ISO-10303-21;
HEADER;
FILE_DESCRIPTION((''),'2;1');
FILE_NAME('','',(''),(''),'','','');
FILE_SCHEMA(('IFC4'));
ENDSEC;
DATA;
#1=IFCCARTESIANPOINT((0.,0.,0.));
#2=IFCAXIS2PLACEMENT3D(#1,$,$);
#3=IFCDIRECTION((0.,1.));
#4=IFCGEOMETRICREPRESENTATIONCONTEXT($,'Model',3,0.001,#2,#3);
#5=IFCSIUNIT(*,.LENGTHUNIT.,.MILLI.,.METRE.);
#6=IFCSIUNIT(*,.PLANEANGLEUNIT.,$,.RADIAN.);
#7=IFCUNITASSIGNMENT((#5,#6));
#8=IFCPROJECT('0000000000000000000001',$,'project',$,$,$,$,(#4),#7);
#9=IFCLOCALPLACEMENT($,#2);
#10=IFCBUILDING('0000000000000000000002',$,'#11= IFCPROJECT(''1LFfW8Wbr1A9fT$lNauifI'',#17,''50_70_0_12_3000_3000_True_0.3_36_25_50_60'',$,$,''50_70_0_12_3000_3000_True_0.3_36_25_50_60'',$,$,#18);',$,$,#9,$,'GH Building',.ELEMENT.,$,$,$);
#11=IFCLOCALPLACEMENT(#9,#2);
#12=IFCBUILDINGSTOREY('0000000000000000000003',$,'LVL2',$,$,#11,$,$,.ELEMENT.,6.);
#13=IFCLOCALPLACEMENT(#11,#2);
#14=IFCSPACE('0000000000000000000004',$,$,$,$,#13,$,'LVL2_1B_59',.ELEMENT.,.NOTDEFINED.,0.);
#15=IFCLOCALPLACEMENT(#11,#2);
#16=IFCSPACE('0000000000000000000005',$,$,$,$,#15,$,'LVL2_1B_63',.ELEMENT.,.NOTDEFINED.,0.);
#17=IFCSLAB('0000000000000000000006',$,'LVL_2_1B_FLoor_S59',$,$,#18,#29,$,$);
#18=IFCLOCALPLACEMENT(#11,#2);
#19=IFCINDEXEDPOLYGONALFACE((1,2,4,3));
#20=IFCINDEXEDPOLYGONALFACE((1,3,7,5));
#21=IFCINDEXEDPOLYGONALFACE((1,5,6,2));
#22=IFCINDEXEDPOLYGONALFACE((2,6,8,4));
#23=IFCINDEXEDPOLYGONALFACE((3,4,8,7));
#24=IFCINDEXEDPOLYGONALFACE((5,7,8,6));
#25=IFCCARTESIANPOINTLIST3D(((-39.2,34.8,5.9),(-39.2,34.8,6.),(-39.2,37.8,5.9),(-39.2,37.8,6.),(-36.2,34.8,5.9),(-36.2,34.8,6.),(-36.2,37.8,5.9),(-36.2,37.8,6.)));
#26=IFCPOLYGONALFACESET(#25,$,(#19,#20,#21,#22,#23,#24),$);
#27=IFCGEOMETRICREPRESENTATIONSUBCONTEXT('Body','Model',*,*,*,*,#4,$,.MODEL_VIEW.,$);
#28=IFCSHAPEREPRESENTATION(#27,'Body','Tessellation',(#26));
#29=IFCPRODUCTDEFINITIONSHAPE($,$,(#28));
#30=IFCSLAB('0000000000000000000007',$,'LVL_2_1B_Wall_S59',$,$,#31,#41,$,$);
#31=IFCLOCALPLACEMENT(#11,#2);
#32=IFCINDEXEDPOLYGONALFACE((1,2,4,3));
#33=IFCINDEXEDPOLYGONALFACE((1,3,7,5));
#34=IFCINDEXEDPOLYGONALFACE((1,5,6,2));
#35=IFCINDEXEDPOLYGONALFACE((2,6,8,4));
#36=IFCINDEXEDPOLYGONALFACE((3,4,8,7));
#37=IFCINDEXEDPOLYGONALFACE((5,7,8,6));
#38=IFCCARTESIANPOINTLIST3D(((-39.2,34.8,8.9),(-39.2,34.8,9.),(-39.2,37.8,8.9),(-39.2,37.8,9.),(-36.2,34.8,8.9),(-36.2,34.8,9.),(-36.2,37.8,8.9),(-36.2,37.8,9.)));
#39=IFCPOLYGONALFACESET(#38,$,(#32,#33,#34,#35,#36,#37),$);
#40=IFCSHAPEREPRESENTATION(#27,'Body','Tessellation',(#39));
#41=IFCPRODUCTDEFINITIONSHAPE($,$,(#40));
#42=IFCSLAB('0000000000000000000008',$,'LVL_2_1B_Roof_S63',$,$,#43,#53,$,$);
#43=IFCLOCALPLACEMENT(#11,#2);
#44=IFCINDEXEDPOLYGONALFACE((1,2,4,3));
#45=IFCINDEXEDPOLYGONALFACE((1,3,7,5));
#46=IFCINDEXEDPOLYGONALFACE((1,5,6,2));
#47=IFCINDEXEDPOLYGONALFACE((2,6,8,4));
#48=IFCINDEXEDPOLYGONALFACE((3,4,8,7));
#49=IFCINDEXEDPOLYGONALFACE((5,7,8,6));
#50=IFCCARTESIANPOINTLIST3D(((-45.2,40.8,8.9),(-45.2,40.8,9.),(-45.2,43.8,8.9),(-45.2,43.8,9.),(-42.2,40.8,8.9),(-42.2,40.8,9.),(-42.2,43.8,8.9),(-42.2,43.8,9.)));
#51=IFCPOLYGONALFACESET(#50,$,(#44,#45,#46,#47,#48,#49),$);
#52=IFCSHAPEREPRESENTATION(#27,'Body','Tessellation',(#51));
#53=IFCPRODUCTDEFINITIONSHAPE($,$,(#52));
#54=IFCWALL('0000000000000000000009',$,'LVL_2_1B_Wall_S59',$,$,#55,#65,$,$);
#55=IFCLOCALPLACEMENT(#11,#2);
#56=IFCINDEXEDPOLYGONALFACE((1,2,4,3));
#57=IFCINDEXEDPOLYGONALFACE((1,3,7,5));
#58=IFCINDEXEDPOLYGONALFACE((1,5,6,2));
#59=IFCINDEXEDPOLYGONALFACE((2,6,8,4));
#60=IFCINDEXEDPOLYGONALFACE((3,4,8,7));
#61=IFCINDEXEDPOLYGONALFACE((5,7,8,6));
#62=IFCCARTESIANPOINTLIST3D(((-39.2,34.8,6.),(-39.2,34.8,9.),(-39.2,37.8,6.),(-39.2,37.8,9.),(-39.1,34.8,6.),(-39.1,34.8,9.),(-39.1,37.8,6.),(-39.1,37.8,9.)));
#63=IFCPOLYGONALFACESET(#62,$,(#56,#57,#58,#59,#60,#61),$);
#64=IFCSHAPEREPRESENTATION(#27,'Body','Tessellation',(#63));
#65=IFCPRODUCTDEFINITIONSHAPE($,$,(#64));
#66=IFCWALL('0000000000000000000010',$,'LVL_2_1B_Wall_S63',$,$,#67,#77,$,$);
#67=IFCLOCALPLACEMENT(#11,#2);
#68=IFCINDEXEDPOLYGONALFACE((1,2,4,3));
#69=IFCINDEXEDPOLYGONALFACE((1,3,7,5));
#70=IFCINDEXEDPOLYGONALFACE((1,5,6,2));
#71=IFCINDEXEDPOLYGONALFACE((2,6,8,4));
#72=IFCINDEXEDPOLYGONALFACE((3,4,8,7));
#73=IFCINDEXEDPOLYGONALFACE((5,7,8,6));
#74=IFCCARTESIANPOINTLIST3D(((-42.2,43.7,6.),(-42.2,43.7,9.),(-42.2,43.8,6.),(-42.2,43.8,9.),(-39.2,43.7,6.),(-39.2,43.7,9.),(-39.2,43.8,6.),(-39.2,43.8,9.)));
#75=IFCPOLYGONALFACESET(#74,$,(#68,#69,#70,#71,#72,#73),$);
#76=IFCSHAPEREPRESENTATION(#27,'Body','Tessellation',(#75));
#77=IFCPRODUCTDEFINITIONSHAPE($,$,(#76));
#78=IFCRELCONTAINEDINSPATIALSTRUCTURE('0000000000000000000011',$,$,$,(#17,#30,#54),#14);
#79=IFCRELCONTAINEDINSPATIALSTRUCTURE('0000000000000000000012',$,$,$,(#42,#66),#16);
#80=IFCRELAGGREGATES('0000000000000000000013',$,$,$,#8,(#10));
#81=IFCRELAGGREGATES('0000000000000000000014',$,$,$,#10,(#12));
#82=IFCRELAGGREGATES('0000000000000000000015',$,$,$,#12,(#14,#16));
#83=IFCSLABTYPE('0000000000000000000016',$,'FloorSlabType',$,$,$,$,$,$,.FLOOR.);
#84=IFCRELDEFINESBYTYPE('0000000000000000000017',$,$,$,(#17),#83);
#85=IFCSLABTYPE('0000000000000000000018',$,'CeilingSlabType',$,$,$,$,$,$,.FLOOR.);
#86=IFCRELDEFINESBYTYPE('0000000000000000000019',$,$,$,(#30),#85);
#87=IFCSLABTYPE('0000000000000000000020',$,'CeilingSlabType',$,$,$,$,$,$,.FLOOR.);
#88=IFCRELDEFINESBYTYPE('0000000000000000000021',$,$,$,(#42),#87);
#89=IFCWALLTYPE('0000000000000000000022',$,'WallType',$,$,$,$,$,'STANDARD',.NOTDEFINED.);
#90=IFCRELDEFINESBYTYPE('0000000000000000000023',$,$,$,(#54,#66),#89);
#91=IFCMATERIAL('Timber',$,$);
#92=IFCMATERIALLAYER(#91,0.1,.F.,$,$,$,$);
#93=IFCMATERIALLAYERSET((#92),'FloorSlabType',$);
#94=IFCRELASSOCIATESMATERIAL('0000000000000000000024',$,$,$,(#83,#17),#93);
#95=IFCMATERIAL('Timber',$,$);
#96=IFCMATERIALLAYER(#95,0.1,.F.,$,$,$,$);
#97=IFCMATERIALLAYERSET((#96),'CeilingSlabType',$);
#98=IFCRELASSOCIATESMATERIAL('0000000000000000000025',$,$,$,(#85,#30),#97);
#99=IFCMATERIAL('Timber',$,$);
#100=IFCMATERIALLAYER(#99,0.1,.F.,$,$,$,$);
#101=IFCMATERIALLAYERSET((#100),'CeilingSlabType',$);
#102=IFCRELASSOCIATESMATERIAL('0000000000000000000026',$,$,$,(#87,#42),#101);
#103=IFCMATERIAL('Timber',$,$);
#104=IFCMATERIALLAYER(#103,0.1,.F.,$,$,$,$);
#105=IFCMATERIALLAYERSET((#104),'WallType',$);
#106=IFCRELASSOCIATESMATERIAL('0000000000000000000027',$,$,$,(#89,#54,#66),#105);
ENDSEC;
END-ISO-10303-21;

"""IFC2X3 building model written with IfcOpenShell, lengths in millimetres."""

from ifc_helpers import new_model, si_unit, direction, frame, frame_2d, origin, place, context, subcontext, project, spatial, rectangle, extrude, material, layer, layer_set, layer_usage, type_object, element, save


model = new_model("IFC2X3")

# Units and contexts
model_context = context("Model", 3, precision=0.001, world=origin(), true_north=direction((0.0, 1.0)))
body_context = subcontext(model_context, "Body", "Model", "MODEL_VIEW")
ifc_project = project(units=[si_unit("LENGTHUNIT", "METRE", prefix="MILLI"), si_unit("PLANEANGLEUNIT", "RADIAN")], contexts=[model_context])

# Building, storey
building_placement = place(None, origin())
building = spatial("IfcBuilding", under=ifc_project, at=building_placement, Name="#11= IFCPROJECT('1LFfW8Wbr1A9fT$lNauifI',#17,'50_70_0_12_3000_3000_True_0.3_36_25_50_60',$,$,'50_70_0_12_3000_3000_True_0.3_36_25_50_60',$,$,#18);", LongName="GH Building", CompositionType="ELEMENT")
storey_placement = place(building_placement, origin())
storey = spatial("IfcBuildingStorey", under=building, at=storey_placement, Name="LVL2", CompositionType="ELEMENT", Elevation=6.0)

# Shared definitions
space_1_placement = place(storey_placement, origin())
space_1 = spatial("IfcSpace", under=storey, at=space_1_placement, LongName="LVL2_1B_59", CompositionType="ELEMENT", InteriorOrExteriorSpace="NOTDEFINED", ElevationWithFlooring=0.0)

# Slabs
ifc_material_1 = material(Name="Timber")
ifc_layer_1 = layer(ifc_material_1, 0.1, ventilated=False)
ifc_layer_set_1 = layer_set([ifc_layer_1], Name="FloorSlabType")
ifc_layer_usage_1 = layer_usage(ifc_layer_set_1, "AXIS3", "NEGATIVE", -0.1)
slab_type_1 = type_object("IfcSlabType", Name="FloorSlabType", PredefinedType="FLOOR", material=ifc_layer_set_1)
slab_1_placement = place(space_1_placement, frame((-39.2, 37.8, 5.9), z_axis=(0.0, 0.0, 1.0), x_axis=(0.0, -1.0, 0.0)))
element("IfcSlab", 1, at=slab_1_placement, inside=space_1, type_object=slab_type_1, material=ifc_layer_usage_1, Name="LVL_2_1B_FLoor_S59", context=body_context, shape_type="SweptSolid", body=[
    extrude(rectangle(XDim=3.0, YDim=3.0, at=frame_2d((1.5, 1.5))), origin(), (0.0, 0.0, 1.0), 0.1),
])
ifc_material_2 = material(Name="Timber")
ifc_layer_2 = layer(ifc_material_2, 0.1, ventilated=False)
ifc_layer_set_2 = layer_set([ifc_layer_2], Name="CeilingSlabType")
ifc_layer_usage_2 = layer_usage(ifc_layer_set_2, "AXIS3", "NEGATIVE", -0.1)
slab_type_2 = type_object("IfcSlabType", Name="CeilingSlabType", PredefinedType="FLOOR", material=ifc_layer_set_2)
slab_2_placement = place(space_1_placement, frame((-39.2, 37.8, 8.9), z_axis=(0.0, 0.0, 1.0), x_axis=(0.0, -1.0, 0.0)))
element("IfcSlab", 2, at=slab_2_placement, inside=space_1, type_object=slab_type_2, material=ifc_layer_usage_2, Name="LVL_2_1B_Wall_S59", context=body_context, shape_type="SweptSolid", body=[
    extrude(rectangle(XDim=3.0, YDim=3.0, at=frame_2d((1.5, 1.5))), origin(), (0.0, 0.0, 1.0), 0.1),
])

# Shared definitions
space_2_placement = place(storey_placement, origin())
space_2 = spatial("IfcSpace", under=storey, at=space_2_placement, LongName="LVL2_1B_63", CompositionType="ELEMENT", InteriorOrExteriorSpace="NOTDEFINED", ElevationWithFlooring=0.0)

# Slab
ifc_material_3 = material(Name="Timber")
ifc_layer_3 = layer(ifc_material_3, 0.1, ventilated=False)
ifc_layer_set_3 = layer_set([ifc_layer_3], Name="CeilingSlabType")
ifc_layer_usage_3 = layer_usage(ifc_layer_set_3, "AXIS3", "NEGATIVE", -0.1)
slab_type_3 = type_object("IfcSlabType", Name="CeilingSlabType", PredefinedType="FLOOR", material=ifc_layer_set_3)
slab_3_placement = place(space_2_placement, frame((-42.2, 43.8, 8.9), z_axis=(0.0, 0.0, 1.0), x_axis=(-1.0, 0.0, 0.0)))
element("IfcSlab", 3, at=slab_3_placement, inside=space_2, type_object=slab_type_3, material=ifc_layer_usage_3, Name="LVL_2_1B_Roof_S63", context=body_context, shape_type="SweptSolid", body=[
    extrude(rectangle(XDim=3.0, YDim=3.0, at=frame_2d((1.5, 1.5))), origin(), (0.0, 0.0, 1.0), 0.1),
])

# Walls
ifc_material_4 = material(Name="Timber")
ifc_layer_4 = layer(ifc_material_4, 0.1, ventilated=False)
ifc_layer_set_4 = layer_set([ifc_layer_4], Name="WallType")
ifc_layer_usage_4 = layer_usage(ifc_layer_set_4, "AXIS2", "NEGATIVE", 0.0)
wall_type_1 = type_object("IfcWallType", Name="WallType", ElementType="STANDARD", PredefinedType="NOTDEFINED", material=ifc_layer_set_4)
wall_1_placement = place(space_1_placement, frame((-39.2, 34.8, 6.0), z_axis=(0.0, 0.0, 1.0), x_axis=(0.0, 1.0, 0.0)))
element("IfcWall", 4, at=wall_1_placement, inside=space_1, type_object=wall_type_1, material=ifc_layer_usage_4, Name="LVL_2_1B_Wall_S59", context=body_context, shape_type="SweptSolid", body=[
    extrude(rectangle(XDim=3.0, YDim=0.1, at=frame_2d((1.5, -0.1))), origin(), (0.0, 0.0, 1.0), 3.0),
])
ifc_layer_usage_5 = layer_usage(ifc_layer_set_4, "AXIS2", "NEGATIVE", 0.0)
wall_2_placement = place(space_2_placement, frame((-42.2, 43.8, 6.0)))
element("IfcWall", 5, at=wall_2_placement, inside=space_2, type_object=wall_type_1, material=ifc_layer_usage_5, Name="LVL_2_1B_Wall_S63", context=body_context, shape_type="SweptSolid", body=[
    extrude(rectangle(XDim=3.0, YDim=0.1, at=frame_2d((1.5, -0.1))), origin(), (0.0, 0.0, 1.0), 3.0),
])

save(model, "model.ifc")
